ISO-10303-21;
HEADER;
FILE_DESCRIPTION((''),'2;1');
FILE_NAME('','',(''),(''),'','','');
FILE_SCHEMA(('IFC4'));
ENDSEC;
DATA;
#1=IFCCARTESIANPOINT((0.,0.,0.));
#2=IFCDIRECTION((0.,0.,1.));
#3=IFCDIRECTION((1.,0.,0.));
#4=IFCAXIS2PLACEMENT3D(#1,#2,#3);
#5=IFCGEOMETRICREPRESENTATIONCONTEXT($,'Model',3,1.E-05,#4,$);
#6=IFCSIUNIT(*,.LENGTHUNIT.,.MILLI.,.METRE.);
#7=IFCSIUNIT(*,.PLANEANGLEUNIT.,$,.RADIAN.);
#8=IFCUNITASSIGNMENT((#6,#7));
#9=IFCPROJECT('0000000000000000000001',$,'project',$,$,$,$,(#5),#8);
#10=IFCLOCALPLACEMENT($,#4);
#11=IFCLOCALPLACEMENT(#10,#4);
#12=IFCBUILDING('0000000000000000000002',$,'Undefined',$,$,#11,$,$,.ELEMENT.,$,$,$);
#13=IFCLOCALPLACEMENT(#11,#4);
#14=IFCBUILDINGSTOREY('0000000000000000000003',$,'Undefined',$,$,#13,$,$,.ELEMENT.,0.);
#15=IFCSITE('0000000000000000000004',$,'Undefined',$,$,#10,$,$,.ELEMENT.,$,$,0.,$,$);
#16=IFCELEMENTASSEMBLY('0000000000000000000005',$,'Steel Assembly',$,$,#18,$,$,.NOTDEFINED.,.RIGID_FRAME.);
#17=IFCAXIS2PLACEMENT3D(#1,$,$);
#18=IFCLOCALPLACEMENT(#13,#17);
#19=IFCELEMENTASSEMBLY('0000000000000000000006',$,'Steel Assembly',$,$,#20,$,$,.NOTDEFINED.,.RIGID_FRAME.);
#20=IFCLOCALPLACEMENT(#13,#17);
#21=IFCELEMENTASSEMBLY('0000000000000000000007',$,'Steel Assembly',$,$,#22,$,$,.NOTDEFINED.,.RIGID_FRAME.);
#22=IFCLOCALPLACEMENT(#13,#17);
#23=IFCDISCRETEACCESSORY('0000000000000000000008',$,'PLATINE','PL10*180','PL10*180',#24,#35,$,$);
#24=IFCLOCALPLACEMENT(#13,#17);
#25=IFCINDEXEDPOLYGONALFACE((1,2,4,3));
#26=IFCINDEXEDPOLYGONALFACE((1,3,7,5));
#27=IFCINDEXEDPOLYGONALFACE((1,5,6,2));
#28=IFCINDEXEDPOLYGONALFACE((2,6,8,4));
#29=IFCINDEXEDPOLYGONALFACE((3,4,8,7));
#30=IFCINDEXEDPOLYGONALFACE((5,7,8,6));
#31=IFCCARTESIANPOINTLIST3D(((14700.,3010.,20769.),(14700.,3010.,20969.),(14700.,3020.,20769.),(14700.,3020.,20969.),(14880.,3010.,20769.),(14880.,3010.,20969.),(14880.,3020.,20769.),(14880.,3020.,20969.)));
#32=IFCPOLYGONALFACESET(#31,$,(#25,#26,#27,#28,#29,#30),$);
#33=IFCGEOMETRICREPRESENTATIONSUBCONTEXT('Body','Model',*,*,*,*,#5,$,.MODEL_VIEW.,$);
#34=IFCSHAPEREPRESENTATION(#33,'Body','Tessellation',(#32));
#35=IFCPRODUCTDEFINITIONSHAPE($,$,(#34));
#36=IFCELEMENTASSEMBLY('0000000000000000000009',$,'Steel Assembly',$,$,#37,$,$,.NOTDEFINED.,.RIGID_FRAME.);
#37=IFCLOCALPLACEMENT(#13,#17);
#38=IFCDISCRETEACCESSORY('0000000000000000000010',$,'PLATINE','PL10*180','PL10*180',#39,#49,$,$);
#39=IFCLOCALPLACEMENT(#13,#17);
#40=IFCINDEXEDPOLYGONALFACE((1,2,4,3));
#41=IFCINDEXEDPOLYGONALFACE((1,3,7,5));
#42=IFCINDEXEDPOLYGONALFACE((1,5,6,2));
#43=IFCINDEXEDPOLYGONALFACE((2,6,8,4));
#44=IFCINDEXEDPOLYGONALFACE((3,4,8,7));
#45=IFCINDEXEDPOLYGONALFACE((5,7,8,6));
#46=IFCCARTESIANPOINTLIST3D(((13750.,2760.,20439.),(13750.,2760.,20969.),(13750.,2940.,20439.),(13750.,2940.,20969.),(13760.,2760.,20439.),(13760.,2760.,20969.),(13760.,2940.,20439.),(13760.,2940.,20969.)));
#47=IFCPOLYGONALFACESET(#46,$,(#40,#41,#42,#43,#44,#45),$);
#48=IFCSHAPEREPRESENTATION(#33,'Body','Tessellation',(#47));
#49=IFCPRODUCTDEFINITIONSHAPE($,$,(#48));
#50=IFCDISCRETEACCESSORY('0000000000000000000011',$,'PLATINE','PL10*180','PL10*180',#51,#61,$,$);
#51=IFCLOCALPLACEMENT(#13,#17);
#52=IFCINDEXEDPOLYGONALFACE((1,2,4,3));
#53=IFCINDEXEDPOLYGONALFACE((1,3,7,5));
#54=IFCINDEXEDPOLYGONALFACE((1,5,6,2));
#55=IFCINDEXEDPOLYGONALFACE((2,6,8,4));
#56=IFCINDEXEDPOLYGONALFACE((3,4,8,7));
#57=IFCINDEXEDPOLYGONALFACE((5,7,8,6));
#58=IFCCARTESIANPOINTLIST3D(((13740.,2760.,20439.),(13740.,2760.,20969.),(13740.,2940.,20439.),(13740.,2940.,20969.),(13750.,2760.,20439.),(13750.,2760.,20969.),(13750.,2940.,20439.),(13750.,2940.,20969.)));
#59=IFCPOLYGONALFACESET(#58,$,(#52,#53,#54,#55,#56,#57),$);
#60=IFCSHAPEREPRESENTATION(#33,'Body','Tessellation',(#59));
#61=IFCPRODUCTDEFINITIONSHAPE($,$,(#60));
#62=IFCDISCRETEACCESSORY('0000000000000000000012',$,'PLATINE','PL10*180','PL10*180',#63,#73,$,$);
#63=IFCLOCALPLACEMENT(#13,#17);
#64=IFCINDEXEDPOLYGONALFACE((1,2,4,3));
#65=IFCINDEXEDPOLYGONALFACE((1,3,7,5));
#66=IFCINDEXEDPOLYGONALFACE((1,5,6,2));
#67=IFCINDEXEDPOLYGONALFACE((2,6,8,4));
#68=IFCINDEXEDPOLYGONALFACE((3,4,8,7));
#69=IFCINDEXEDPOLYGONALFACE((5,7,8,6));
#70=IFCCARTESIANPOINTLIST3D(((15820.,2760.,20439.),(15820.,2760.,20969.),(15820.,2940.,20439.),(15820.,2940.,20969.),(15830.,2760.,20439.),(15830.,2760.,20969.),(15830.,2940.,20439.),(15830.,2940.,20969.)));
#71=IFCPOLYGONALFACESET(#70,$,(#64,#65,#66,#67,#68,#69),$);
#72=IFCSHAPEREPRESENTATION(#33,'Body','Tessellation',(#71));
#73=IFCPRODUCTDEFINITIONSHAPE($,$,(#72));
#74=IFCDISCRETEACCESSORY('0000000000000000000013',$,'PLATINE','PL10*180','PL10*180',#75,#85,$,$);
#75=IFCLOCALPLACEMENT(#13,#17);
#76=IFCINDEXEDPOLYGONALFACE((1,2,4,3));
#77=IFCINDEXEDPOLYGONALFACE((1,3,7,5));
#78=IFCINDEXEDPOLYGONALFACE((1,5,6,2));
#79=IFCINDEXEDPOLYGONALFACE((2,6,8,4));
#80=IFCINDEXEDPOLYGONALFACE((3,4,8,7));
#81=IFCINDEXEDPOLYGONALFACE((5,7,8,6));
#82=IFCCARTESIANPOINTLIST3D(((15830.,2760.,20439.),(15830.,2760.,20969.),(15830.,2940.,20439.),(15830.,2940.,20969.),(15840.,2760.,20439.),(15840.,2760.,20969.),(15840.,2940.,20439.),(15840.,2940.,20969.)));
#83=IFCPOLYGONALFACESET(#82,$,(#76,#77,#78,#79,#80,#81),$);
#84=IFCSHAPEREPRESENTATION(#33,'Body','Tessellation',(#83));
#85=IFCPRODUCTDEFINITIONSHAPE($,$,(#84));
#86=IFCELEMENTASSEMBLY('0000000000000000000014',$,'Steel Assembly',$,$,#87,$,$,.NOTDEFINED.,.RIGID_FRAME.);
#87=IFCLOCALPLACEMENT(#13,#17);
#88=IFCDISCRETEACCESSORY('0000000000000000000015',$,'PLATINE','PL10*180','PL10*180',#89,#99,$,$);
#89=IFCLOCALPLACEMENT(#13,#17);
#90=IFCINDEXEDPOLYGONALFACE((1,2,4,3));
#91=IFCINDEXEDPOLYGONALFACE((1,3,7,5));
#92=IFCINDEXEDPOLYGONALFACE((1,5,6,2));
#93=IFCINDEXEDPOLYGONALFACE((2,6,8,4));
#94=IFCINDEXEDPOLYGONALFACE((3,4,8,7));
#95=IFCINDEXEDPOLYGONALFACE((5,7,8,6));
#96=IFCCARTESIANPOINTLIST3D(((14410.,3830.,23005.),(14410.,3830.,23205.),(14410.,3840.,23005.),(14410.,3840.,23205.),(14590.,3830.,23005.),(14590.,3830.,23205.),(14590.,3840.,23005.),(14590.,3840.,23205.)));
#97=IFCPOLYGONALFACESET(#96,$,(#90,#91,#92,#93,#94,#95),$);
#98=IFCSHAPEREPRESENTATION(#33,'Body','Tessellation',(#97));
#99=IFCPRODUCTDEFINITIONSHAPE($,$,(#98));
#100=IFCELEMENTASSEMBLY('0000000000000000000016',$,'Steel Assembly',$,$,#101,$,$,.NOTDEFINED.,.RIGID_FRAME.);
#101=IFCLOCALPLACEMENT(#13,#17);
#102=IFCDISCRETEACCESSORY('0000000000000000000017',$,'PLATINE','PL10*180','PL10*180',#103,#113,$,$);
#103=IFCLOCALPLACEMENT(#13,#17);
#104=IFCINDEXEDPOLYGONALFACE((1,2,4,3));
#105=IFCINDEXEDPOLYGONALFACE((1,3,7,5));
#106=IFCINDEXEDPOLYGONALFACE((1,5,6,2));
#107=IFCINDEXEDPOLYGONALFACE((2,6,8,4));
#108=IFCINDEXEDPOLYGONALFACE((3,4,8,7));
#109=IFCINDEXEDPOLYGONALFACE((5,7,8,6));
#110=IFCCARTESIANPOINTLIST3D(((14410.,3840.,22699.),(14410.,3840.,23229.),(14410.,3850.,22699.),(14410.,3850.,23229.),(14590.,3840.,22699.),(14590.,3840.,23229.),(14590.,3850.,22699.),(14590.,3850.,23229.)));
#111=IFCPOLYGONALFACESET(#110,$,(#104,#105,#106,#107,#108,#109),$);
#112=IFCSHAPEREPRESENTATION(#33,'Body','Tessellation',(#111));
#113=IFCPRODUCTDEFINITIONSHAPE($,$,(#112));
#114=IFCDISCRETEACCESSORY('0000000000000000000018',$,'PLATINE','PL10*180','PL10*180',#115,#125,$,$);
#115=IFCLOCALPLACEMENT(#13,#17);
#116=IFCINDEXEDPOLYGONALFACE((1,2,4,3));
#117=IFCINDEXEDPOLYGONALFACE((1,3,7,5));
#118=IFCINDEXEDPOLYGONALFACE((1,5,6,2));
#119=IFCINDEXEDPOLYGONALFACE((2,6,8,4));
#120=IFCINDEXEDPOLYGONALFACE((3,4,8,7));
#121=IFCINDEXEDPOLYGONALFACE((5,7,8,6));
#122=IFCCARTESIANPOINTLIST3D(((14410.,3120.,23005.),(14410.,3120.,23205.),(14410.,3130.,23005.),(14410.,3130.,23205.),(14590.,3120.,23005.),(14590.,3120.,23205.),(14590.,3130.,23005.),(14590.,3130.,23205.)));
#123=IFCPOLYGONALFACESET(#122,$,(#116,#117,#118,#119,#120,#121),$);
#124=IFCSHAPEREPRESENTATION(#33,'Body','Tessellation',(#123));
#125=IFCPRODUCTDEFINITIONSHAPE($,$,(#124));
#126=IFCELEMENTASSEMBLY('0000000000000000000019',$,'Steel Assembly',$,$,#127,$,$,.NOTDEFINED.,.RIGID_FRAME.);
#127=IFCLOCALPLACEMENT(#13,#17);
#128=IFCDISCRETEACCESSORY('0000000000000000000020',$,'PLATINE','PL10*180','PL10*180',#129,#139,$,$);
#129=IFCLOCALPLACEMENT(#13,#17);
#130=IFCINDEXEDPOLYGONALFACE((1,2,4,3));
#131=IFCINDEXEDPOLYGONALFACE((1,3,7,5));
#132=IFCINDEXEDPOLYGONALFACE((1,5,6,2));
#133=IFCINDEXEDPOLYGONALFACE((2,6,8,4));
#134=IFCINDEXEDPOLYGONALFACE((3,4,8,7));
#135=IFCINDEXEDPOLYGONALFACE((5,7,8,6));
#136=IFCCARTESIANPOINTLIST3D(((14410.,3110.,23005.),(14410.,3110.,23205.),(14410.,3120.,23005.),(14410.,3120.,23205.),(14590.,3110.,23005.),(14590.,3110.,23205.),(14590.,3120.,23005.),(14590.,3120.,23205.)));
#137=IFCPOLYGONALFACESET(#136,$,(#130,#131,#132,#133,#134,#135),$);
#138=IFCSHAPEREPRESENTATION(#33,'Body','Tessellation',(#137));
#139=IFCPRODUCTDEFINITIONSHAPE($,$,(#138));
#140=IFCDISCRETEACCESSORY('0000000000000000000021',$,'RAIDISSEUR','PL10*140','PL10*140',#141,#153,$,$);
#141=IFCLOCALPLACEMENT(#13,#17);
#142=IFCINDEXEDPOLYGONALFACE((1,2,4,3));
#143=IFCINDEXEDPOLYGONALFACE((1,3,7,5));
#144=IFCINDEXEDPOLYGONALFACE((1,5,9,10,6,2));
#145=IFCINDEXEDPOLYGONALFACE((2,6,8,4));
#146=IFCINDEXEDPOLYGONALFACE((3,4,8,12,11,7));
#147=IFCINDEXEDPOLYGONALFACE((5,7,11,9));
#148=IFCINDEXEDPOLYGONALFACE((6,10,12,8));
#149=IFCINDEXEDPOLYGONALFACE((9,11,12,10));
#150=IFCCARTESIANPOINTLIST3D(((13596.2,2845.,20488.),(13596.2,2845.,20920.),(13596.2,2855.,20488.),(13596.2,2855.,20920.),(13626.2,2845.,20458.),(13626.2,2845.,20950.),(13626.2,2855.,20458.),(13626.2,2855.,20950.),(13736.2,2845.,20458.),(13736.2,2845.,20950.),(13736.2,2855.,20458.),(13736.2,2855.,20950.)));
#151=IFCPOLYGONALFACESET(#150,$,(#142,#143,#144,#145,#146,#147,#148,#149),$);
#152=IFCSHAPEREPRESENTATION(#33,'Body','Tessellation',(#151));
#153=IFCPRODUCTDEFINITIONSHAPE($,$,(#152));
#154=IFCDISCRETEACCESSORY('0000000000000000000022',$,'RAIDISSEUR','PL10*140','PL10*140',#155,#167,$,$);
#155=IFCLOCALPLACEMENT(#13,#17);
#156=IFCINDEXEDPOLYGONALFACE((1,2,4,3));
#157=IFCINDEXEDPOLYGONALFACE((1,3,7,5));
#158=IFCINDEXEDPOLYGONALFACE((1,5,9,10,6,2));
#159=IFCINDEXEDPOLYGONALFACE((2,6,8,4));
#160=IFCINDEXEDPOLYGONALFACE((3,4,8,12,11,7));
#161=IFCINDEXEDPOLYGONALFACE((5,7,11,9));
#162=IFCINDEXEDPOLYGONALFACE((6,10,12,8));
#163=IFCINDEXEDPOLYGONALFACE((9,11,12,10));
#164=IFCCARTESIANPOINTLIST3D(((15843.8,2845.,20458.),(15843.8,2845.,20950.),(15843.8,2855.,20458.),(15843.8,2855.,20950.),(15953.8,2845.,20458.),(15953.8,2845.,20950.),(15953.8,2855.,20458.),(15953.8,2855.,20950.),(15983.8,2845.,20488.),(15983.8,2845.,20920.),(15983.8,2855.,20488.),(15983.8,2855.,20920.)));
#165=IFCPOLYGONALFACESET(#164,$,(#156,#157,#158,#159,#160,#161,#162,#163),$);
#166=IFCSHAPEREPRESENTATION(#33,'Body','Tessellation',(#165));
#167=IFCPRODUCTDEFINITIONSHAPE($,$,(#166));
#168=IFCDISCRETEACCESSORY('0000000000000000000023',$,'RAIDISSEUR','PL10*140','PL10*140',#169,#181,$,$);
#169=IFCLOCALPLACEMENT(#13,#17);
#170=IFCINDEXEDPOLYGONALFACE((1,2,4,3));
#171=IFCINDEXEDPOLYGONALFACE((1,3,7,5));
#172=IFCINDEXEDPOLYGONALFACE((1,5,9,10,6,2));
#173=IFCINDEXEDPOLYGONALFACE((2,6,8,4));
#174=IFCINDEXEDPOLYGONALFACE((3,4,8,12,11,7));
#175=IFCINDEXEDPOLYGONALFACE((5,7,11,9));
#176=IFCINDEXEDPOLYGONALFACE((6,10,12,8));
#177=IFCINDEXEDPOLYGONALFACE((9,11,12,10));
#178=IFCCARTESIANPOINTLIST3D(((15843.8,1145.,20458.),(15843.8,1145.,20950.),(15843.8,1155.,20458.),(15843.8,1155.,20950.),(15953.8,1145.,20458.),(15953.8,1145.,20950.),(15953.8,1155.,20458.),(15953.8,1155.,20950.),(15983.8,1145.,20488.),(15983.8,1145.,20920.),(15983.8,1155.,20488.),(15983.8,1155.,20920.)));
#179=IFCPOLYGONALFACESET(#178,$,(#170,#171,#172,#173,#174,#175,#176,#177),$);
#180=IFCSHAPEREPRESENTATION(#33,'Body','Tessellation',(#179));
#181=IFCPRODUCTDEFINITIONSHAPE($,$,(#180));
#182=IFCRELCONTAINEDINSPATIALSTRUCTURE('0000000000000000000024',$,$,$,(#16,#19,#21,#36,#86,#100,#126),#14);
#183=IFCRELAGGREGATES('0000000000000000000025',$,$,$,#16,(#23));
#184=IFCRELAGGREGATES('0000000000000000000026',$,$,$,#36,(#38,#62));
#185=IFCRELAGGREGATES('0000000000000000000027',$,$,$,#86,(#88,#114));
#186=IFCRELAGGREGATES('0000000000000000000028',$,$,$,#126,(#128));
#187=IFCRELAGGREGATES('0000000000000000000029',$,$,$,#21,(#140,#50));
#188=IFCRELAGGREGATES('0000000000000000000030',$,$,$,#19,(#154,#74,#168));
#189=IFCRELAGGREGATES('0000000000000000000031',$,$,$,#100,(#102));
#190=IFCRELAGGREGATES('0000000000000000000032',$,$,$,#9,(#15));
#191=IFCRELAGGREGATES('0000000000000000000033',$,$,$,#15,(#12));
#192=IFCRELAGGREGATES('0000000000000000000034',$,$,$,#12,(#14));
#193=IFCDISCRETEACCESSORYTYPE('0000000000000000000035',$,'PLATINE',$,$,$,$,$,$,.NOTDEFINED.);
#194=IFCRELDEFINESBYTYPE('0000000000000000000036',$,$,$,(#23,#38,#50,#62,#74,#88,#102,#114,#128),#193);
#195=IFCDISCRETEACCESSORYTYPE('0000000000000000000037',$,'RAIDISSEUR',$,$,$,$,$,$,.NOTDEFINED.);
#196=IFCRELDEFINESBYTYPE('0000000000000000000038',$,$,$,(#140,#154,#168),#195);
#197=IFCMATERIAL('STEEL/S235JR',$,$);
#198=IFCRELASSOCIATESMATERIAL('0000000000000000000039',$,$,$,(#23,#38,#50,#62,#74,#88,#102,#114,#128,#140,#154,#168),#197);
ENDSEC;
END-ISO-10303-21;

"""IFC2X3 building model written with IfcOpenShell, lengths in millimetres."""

from ifc_helpers import new_model, si_unit, frame, origin_with_axes, place, context, subcontext, project, spatial, polyline, outline, extrude, material, type_object, element, aggregate, save


model = new_model("IFC2X3")

# Units and contexts
model_context = context("Model", 3, precision=1e-05, world=origin_with_axes())
body_context = subcontext(model_context, "Body", "Model", "MODEL_VIEW")
ifc_project = project(units=[si_unit("LENGTHUNIT", "METRE", prefix="MILLI"), si_unit("PLANEANGLEUNIT", "RADIAN")], contexts=[model_context])

# Site, building, storey
site_placement = place(None, origin_with_axes())
site = spatial("IfcSite", under=ifc_project, at=site_placement, Name="Undefined", CompositionType="ELEMENT", RefElevation=0.0)
building_placement = place(site_placement, origin_with_axes())
building = spatial("IfcBuilding", under=site, at=building_placement, Name="Undefined", CompositionType="ELEMENT")
storey_placement = place(building_placement, origin_with_axes())
storey = spatial("IfcBuildingStorey", under=building, at=storey_placement, Name="Undefined", CompositionType="ELEMENT", Elevation=0.0)

# Shared definitions
ifc_material_1 = material(Name="STEEL/S235JR")

# Element assembly
assembly_1_placement = place(storey_placement, origin_with_axes())
assembly_1 = element("IfcElementAssembly", 1, at=assembly_1_placement, inside=storey, Name="Steel Assembly", AssemblyPlace="NOTDEFINED", PredefinedType="RIGID_FRAME")

# Element assemblies
assembly_2_placement = place(storey_placement, origin_with_axes())
assembly_2 = element("IfcElementAssembly", 2, at=assembly_2_placement, inside=storey, Name="Steel Assembly", AssemblyPlace="NOTDEFINED", PredefinedType="RIGID_FRAME")
assembly_3_placement = place(storey_placement, origin_with_axes())
assembly_3 = element("IfcElementAssembly", 3, at=assembly_3_placement, inside=storey, Name="Steel Assembly", AssemblyPlace="NOTDEFINED", PredefinedType="RIGID_FRAME")

# Discrete accessory
discrete_accessory_type_1 = type_object("IfcDiscreteAccessoryType", Name="PLATINE")
discrete_accessory_1_placement = place(assembly_1_placement, frame((14790.0, 3015.0, 20769.0), z_axis=(0.0, 1.0, 0.0), x_axis=(0.0, 0.0, 1.0)))
discrete_accessory_1 = element("IfcDiscreteAccessory", 4, at=discrete_accessory_1_placement, type_object=discrete_accessory_type_1, material=ifc_material_1, Name="PLATINE", Description="PL10*180", ObjectType="PL10*180", context=body_context, shape_type="SweptSolid", body=[
    extrude(outline(polyline([(0.0, 90.0), (200.0, 90.0), (200.0, -90.0), (0.0, -90.0), (0.0, 90.0)])), frame((0.0, 0.0, -5.0), z_axis=(0.0, 0.0, 1.0), x_axis=(1.0, 0.0, 0.0)), (0.0, 0.0, 1.0), 10.0),
])
aggregate(assembly_1, [discrete_accessory_1])

# Element assembly, discrete accessory
assembly_4_placement = place(storey_placement, origin_with_axes())
assembly_4 = element("IfcElementAssembly", 5, at=assembly_4_placement, inside=storey, Name="Steel Assembly", AssemblyPlace="NOTDEFINED", PredefinedType="RIGID_FRAME")
discrete_accessory_2_placement = place(assembly_4_placement, frame((13755.0, 2850.0, 20969.0), z_axis=(1.0, 0.0, 0.0), x_axis=(0.0, 0.0, -1.0)))
discrete_accessory_2 = element("IfcDiscreteAccessory", 6, at=discrete_accessory_2_placement, type_object=discrete_accessory_type_1, material=ifc_material_1, Name="PLATINE", Description="PL10*180", ObjectType="PL10*180", context=body_context, shape_type="SweptSolid", body=[
    extrude(outline(polyline([(0.0, -90.0), (0.0, 90.0), (530.0, 90.0), (530.0, -90.0), (0.0, -90.0)])), frame((0.0, 0.0, -5.0), z_axis=(0.0, 0.0, 1.0), x_axis=(1.0, 0.0, 0.0)), (0.0, 0.0, 1.0), 10.0),
])

# Discrete accessories
discrete_accessory_3_placement = place(assembly_3_placement, frame((13745.0, 2850.0, 20969.0), z_axis=(1.0, 0.0, 0.0), x_axis=(0.0, 0.0, -1.0)))
discrete_accessory_3 = element("IfcDiscreteAccessory", 7, at=discrete_accessory_3_placement, type_object=discrete_accessory_type_1, material=ifc_material_1, Name="PLATINE", Description="PL10*180", ObjectType="PL10*180", context=body_context, shape_type="SweptSolid", body=[
    extrude(outline(polyline([(0.0, -90.0), (0.0, 90.0), (530.0, 90.0), (530.0, -90.0), (0.0, -90.0)])), frame((0.0, 0.0, -5.0), z_axis=(0.0, 0.0, 1.0), x_axis=(1.0, 0.0, 0.0)), (0.0, 0.0, 1.0), 10.0),
])
discrete_accessory_4_placement = place(assembly_4_placement, frame((15825.0, 2850.0, 20969.0), z_axis=(-1.0, 0.0, 0.0), x_axis=(0.0, 0.0, -1.0)))
discrete_accessory_4 = element("IfcDiscreteAccessory", 8, at=discrete_accessory_4_placement, type_object=discrete_accessory_type_1, material=ifc_material_1, Name="PLATINE", Description="PL10*180", ObjectType="PL10*180", context=body_context, shape_type="SweptSolid", body=[
    extrude(outline(polyline([(530.0, -90.0), (0.0, -90.0), (0.0, 90.0), (530.0, 90.0), (530.0, -90.0)])), frame((0.0, 0.0, -5.0), z_axis=(0.0, 0.0, 1.0), x_axis=(1.0, 0.0, 0.0)), (0.0, 0.0, 1.0), 10.0),
])
aggregate(assembly_4, [discrete_accessory_2, discrete_accessory_4])
discrete_accessory_5_placement = place(assembly_2_placement, frame((15835.0, 2850.0, 20969.0), z_axis=(-1.0, 0.0, 0.0), x_axis=(0.0, 0.0, -1.0)))
discrete_accessory_5 = element("IfcDiscreteAccessory", 9, at=discrete_accessory_5_placement, type_object=discrete_accessory_type_1, material=ifc_material_1, Name="PLATINE", Description="PL10*180", ObjectType="PL10*180", context=body_context, shape_type="SweptSolid", body=[
    extrude(outline(polyline([(530.0, -90.0), (0.0, -90.0), (0.0, 90.0), (530.0, 90.0), (530.0, -90.0)])), frame((0.0, 0.0, -5.0), z_axis=(0.0, 0.0, 1.0), x_axis=(1.0, 0.0, 0.0)), (0.0, 0.0, 1.0), 10.0),
])

# Element assemblies, discrete accessories
assembly_5_placement = place(storey_placement, origin_with_axes())
assembly_5 = element("IfcElementAssembly", 10, at=assembly_5_placement, inside=storey, Name="Steel Assembly", AssemblyPlace="NOTDEFINED", PredefinedType="RIGID_FRAME")
discrete_accessory_6_placement = place(assembly_5_placement, frame((14500.0, 3835.0, 23005.0), z_axis=(0.0, -1.0, 0.0), x_axis=(0.0, 0.0, 1.0)))
discrete_accessory_6 = element("IfcDiscreteAccessory", 11, at=discrete_accessory_6_placement, type_object=discrete_accessory_type_1, material=ifc_material_1, Name="PLATINE", Description="PL10*180", ObjectType="PL10*180", context=body_context, shape_type="SweptSolid", body=[
    extrude(outline(polyline([(200.0, 90.0), (200.0, -90.0), (0.0, -90.0), (0.0, 90.0), (200.0, 90.0)])), frame((0.0, 0.0, -5.0), z_axis=(0.0, 0.0, 1.0), x_axis=(1.0, 0.0, 0.0)), (0.0, 0.0, 1.0), 10.0),
])
assembly_6_placement = place(storey_placement, origin_with_axes())
assembly_6 = element("IfcElementAssembly", 12, at=assembly_6_placement, inside=storey, Name="Steel Assembly", AssemblyPlace="NOTDEFINED", PredefinedType="RIGID_FRAME")
discrete_accessory_7_placement = place(assembly_6_placement, frame((14500.0, 3845.0, 22699.0), z_axis=(0.0, -1.0, 0.0), x_axis=(0.0, 0.0, 1.0)))
discrete_accessory_7 = element("IfcDiscreteAccessory", 13, at=discrete_accessory_7_placement, type_object=discrete_accessory_type_1, material=ifc_material_1, Name="PLATINE", Description="PL10*180", ObjectType="PL10*180", context=body_context, shape_type="SweptSolid", body=[
    extrude(outline(polyline([(530.0, 90.0), (530.0, -90.0), (0.0, -90.0), (0.0, 90.0), (530.0, 90.0)])), frame((0.0, 0.0, -5.0), z_axis=(0.0, 0.0, 1.0), x_axis=(1.0, 0.0, 0.0)), (0.0, 0.0, 1.0), 10.0),
])

# Discrete accessory
discrete_accessory_8_placement = place(assembly_5_placement, frame((14500.0, 3125.0, 23005.0), z_axis=(0.0, 1.0, 0.0), x_axis=(0.0, 0.0, 1.0)))
discrete_accessory_8 = element("IfcDiscreteAccessory", 14, at=discrete_accessory_8_placement, type_object=discrete_accessory_type_1, material=ifc_material_1, Name="PLATINE", Description="PL10*180", ObjectType="PL10*180", context=body_context, shape_type="SweptSolid", body=[
    extrude(outline(polyline([(0.0, 90.0), (200.0, 90.0), (200.0, -90.0), (0.0, -90.0), (0.0, 90.0)])), frame((0.0, 0.0, -5.0), z_axis=(0.0, 0.0, 1.0), x_axis=(1.0, 0.0, 0.0)), (0.0, 0.0, 1.0), 10.0),
])
aggregate(assembly_5, [discrete_accessory_6, discrete_accessory_8])

# Element assembly, discrete accessory
assembly_7_placement = place(storey_placement, origin_with_axes())
assembly_7 = element("IfcElementAssembly", 15, at=assembly_7_placement, inside=storey, Name="Steel Assembly", AssemblyPlace="NOTDEFINED", PredefinedType="RIGID_FRAME")
discrete_accessory_9_placement = place(assembly_7_placement, frame((14500.0, 3115.0, 23005.0), z_axis=(0.0, 1.0, 0.0), x_axis=(0.0, 0.0, 1.0)))
discrete_accessory_9 = element("IfcDiscreteAccessory", 16, at=discrete_accessory_9_placement, type_object=discrete_accessory_type_1, material=ifc_material_1, Name="PLATINE", Description="PL10*180", ObjectType="PL10*180", context=body_context, shape_type="SweptSolid", body=[
    extrude(outline(polyline([(0.0, 90.0), (200.0, 90.0), (200.0, -90.0), (0.0, -90.0), (0.0, 90.0)])), frame((0.0, 0.0, -5.0), z_axis=(0.0, 0.0, 1.0), x_axis=(1.0, 0.0, 0.0)), (0.0, 0.0, 1.0), 10.0),
])
aggregate(assembly_7, [discrete_accessory_9])

# Discrete accessories
discrete_accessory_type_2 = type_object("IfcDiscreteAccessoryType", Name="RAIDISSEUR")
discrete_accessory_10_placement = place(assembly_3_placement, frame((13596.2, 2850.0, 20950.0), z_axis=(0.0, 1.0, 0.0), x_axis=(1.0, 0.0, 0.0)))
discrete_accessory_10 = element("IfcDiscreteAccessory", 17, at=discrete_accessory_10_placement, type_object=discrete_accessory_type_2, material=ifc_material_1, Name="RAIDISSEUR", Description="PL10*140", ObjectType="PL10*140", context=body_context, shape_type="SweptSolid", body=[
    extrude(outline(polyline([(0.0, 30.0), (30.0, 0.0), (140.0, 0.0), (140.0, 492.0), (30.0, 492.0), (0.0, 462.0), (0.0, 30.0)])), frame((0.0, 0.0, -5.0), z_axis=(0.0, 0.0, 1.0), x_axis=(1.0, 0.0, 0.0)), (0.0, 0.0, 1.0), 10.0),
])
aggregate(assembly_3, [discrete_accessory_10, discrete_accessory_3])
discrete_accessory_11_placement = place(assembly_2_placement, frame((15983.8, 2850.0, 20950.0), z_axis=(0.0, -1.0, 0.0), x_axis=(-1.0, 0.0, 0.0)))
discrete_accessory_11 = element("IfcDiscreteAccessory", 18, at=discrete_accessory_11_placement, type_object=discrete_accessory_type_2, material=ifc_material_1, Name="RAIDISSEUR", Description="PL10*140", ObjectType="PL10*140", context=body_context, shape_type="SweptSolid", body=[
    extrude(outline(polyline([(0.0, 30.0), (30.0, 0.0), (140.0, 0.0), (140.0, 492.0), (30.0, 492.0), (0.0, 462.0), (0.0, 30.0)])), frame((0.0, 0.0, -5.0), z_axis=(0.0, 0.0, 1.0), x_axis=(1.0, 0.0, 0.0)), (0.0, 0.0, 1.0), 10.0),
])
discrete_accessory_12_placement = place(assembly_2_placement, frame((15983.8, 1150.0, 20950.0), z_axis=(0.0, -1.0, 0.0), x_axis=(-1.0, 0.0, 0.0)))
discrete_accessory_12 = element("IfcDiscreteAccessory", 19, at=discrete_accessory_12_placement, type_object=discrete_accessory_type_2, material=ifc_material_1, Name="RAIDISSEUR", Description="PL10*140", ObjectType="PL10*140", context=body_context, shape_type="SweptSolid", body=[
    extrude(outline(polyline([(0.0, 30.0), (30.0, 0.0), (140.0, 0.0), (140.0, 492.0), (30.0, 492.0), (0.0, 462.0), (0.0, 30.0)])), frame((0.0, 0.0, -5.0), z_axis=(0.0, 0.0, 1.0), x_axis=(1.0, 0.0, 0.0)), (0.0, 0.0, 1.0), 10.0),
])
aggregate(assembly_2, [discrete_accessory_11, discrete_accessory_5, discrete_accessory_12])

aggregate(assembly_6, [discrete_accessory_7])

save(model, "model.ifc")
